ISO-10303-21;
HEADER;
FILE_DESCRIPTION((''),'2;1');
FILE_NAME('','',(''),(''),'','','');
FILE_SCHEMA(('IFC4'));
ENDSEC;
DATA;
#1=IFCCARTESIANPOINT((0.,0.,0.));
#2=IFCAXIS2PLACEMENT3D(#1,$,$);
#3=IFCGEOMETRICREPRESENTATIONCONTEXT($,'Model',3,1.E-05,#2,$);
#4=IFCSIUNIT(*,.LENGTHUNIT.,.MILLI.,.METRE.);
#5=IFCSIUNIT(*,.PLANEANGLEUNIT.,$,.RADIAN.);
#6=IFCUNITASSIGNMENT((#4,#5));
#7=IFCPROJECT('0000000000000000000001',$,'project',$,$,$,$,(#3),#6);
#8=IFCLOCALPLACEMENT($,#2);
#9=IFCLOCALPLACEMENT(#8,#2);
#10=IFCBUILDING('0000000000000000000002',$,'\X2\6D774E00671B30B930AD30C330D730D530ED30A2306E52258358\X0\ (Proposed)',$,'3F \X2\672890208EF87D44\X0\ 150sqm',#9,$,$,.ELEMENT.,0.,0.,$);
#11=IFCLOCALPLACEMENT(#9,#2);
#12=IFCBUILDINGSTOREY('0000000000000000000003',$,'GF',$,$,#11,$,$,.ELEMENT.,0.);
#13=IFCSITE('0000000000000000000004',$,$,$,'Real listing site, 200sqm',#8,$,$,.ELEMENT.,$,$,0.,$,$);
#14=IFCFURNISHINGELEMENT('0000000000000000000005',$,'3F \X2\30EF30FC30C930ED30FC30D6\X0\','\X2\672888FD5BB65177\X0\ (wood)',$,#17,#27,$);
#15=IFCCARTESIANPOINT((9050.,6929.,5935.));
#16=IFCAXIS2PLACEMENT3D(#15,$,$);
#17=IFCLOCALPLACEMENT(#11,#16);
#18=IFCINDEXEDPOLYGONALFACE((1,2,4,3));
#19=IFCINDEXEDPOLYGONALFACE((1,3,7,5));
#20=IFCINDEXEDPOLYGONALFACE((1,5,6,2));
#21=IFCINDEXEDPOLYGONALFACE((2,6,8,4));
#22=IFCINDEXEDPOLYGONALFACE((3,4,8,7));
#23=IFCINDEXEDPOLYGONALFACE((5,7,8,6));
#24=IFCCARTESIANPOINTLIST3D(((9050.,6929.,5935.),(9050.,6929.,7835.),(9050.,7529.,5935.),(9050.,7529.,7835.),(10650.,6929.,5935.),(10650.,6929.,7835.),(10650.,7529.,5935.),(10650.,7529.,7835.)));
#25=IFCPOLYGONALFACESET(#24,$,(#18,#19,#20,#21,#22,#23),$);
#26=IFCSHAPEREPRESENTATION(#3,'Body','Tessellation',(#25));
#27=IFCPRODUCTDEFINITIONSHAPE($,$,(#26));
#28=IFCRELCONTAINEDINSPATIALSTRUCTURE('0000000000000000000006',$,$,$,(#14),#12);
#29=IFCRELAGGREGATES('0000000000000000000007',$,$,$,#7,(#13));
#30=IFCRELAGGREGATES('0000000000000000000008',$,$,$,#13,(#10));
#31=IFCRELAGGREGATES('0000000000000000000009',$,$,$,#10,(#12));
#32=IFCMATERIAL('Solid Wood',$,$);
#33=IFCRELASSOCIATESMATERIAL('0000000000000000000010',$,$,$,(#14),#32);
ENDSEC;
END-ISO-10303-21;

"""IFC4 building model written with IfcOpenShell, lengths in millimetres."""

from ifc_helpers import new_model, si_unit, frame, frame_2d, origin, place, context, project, spatial, rectangle, extrude, material, element, save


model = new_model("IFC4")

# Units and contexts
model_context = context("Model", 3, precision=1e-05, world=origin())
ifc_project = project(units=[si_unit("LENGTHUNIT", "METRE", prefix="MILLI"), si_unit("PLANEANGLEUNIT", "RADIAN")], contexts=[model_context])

# Site, building, storey
site_placement = place(None, origin())
site = spatial("IfcSite", under=ifc_project, at=site_placement, ObjectType="Real listing site, 200sqm", CompositionType="ELEMENT", RefElevation=0.0)
building_placement = place(site_placement, origin())
building = spatial("IfcBuilding", under=site, at=building_placement, Name="海一望スキップフロアの別荘 (Proposed)", ObjectType="3F 木造軸組 150sqm", CompositionType="ELEMENT", ElevationOfRefHeight=0.0, ElevationOfTerrain=0.0)
storey_placement = place(building_placement, origin())
storey = spatial("IfcBuildingStorey", under=building, at=storey_placement, Name="GF", CompositionType="ELEMENT", Elevation=0.0)

# Shared definitions
ifc_material_1 = material(Name="Solid Wood")

# Furnishing element
furnishing_1_placement = place(storey_placement, frame((9050.0, 6929.0, 5935.0)))
element("IfcFurnishingElement", 1, at=furnishing_1_placement, inside=storey, material=ifc_material_1, Name="3F ワードローブ", Description="木製家具 (wood)", context=model_context, shape_type="SweptSolid", body=[
    extrude(rectangle(XDim=1600.0, YDim=600.0, at=frame_2d((800.0, 300.0))), frame((9050.0, 6929.0, 5935.0)), (0.0, 0.0, 1.0), 1900.0),
])

save(model, "model.ifc")
